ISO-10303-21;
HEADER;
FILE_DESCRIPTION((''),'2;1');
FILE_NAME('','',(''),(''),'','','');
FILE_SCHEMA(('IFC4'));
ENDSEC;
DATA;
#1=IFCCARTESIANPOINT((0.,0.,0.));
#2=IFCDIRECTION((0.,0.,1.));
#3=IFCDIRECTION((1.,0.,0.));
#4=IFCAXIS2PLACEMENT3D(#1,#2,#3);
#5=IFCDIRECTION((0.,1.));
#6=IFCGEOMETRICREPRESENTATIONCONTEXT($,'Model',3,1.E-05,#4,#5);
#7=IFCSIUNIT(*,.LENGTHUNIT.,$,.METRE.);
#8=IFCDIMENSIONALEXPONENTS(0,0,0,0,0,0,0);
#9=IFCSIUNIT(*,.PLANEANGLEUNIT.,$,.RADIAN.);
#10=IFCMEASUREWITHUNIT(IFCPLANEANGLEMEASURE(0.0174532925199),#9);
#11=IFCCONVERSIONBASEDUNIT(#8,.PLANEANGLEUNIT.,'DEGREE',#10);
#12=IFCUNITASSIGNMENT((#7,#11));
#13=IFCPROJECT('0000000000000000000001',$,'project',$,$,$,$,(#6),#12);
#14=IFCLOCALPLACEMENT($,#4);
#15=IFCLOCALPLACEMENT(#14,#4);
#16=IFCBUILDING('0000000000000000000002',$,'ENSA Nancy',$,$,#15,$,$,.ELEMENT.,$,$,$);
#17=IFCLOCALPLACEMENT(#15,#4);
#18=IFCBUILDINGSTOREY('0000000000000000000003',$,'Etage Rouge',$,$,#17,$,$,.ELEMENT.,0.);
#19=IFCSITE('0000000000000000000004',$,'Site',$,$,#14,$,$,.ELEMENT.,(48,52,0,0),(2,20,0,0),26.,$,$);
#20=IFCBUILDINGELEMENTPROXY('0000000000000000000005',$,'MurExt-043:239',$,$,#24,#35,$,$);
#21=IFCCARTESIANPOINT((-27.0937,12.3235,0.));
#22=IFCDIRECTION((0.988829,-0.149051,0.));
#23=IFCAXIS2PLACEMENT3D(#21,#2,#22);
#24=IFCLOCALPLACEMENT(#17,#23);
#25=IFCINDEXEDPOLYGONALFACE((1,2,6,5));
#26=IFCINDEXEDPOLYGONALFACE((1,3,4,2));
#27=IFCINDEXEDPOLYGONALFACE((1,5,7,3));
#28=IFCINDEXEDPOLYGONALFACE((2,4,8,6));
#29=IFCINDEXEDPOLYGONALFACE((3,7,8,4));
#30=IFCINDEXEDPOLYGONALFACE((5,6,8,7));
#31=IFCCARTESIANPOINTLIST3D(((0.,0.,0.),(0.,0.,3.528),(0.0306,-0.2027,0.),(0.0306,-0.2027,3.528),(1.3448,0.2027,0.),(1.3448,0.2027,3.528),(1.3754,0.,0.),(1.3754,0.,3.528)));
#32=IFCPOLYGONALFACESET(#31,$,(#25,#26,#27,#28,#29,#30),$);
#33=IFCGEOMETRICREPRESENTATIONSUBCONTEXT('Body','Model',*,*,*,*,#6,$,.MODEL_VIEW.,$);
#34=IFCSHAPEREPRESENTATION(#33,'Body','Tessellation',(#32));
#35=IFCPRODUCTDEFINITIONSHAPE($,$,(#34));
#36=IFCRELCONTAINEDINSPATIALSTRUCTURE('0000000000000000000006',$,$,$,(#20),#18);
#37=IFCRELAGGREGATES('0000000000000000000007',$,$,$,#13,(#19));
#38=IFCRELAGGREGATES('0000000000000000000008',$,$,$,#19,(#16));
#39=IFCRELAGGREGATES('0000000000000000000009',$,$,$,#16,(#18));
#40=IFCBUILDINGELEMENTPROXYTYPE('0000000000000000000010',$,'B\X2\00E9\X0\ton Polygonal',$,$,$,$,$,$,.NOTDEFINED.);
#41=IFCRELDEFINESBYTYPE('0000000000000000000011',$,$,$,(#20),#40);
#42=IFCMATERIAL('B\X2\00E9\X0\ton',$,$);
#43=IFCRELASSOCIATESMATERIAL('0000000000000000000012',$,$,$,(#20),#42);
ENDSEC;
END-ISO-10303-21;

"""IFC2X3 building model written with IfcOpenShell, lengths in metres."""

from ifc_helpers import new_model, entity, si_unit, converted_unit, direction, frame, origin_with_axes, place, context, subcontext, project, spatial, polyline, outline, extrude, material, type_object, element, save


model = new_model("IFC2X3")

# Units and contexts
model_context = context("Model", 3, precision=1e-05, world=origin_with_axes(), true_north=direction((0.0, 1.0)))
body_context = subcontext(model_context, "Body", "Model", "MODEL_VIEW")
ifc_project = project(units=[si_unit("LENGTHUNIT", "METRE"), converted_unit("PLANEANGLEUNIT", "DEGREE", entity("IfcPlaneAngleMeasure", 0.0174532925199), si_unit("PLANEANGLEUNIT", "RADIAN"), dimensions=[0, 0, 0, 0, 0, 0, 0])], contexts=[model_context])

# Site, building, storey
site_placement = place(None, origin_with_axes())
site = spatial("IfcSite", under=ifc_project, at=site_placement, Name="Site", CompositionType="ELEMENT", RefLatitude=(48, 52, 0, 0), RefLongitude=(2, 20, 0, 0), RefElevation=26.0)
building_placement = place(site_placement, origin_with_axes())
building = spatial("IfcBuilding", under=site, at=building_placement, Name="ENSA Nancy", CompositionType="ELEMENT")
storey_placement = place(building_placement, origin_with_axes())
storey = spatial("IfcBuildingStorey", under=building, at=storey_placement, Name="Etage Rouge", CompositionType="ELEMENT", Elevation=0.0)

# Shared definitions
ifc_material_1 = material(Name="Béton")

# Building element proxy
building_element_proxy_type_1 = type_object("IfcBuildingElementProxyType", Name="Béton Polygonal", PredefinedType="NOTDEFINED")
proxy_1_placement = place(storey_placement, frame((-27.0937, 12.3235, 0.0), z_axis=(0.0, 0.0, 1.0), x_axis=(0.988829, -0.149051, 0.0)))
element("IfcBuildingElementProxy", 1, at=proxy_1_placement, inside=storey, type_object=building_element_proxy_type_1, material=ifc_material_1, Name="MurExt-043:239", context=body_context, shape_type="SweptSolid", body=[
    extrude(outline(polyline([(0.0, 0.0), (0.0306, -0.2027), (1.3754, 0.0), (1.3448, 0.2027), (0.0, 0.0)])), origin_with_axes(), (0.0, 0.0, 1.0), 3.528),
])

save(model, "model.ifc")
